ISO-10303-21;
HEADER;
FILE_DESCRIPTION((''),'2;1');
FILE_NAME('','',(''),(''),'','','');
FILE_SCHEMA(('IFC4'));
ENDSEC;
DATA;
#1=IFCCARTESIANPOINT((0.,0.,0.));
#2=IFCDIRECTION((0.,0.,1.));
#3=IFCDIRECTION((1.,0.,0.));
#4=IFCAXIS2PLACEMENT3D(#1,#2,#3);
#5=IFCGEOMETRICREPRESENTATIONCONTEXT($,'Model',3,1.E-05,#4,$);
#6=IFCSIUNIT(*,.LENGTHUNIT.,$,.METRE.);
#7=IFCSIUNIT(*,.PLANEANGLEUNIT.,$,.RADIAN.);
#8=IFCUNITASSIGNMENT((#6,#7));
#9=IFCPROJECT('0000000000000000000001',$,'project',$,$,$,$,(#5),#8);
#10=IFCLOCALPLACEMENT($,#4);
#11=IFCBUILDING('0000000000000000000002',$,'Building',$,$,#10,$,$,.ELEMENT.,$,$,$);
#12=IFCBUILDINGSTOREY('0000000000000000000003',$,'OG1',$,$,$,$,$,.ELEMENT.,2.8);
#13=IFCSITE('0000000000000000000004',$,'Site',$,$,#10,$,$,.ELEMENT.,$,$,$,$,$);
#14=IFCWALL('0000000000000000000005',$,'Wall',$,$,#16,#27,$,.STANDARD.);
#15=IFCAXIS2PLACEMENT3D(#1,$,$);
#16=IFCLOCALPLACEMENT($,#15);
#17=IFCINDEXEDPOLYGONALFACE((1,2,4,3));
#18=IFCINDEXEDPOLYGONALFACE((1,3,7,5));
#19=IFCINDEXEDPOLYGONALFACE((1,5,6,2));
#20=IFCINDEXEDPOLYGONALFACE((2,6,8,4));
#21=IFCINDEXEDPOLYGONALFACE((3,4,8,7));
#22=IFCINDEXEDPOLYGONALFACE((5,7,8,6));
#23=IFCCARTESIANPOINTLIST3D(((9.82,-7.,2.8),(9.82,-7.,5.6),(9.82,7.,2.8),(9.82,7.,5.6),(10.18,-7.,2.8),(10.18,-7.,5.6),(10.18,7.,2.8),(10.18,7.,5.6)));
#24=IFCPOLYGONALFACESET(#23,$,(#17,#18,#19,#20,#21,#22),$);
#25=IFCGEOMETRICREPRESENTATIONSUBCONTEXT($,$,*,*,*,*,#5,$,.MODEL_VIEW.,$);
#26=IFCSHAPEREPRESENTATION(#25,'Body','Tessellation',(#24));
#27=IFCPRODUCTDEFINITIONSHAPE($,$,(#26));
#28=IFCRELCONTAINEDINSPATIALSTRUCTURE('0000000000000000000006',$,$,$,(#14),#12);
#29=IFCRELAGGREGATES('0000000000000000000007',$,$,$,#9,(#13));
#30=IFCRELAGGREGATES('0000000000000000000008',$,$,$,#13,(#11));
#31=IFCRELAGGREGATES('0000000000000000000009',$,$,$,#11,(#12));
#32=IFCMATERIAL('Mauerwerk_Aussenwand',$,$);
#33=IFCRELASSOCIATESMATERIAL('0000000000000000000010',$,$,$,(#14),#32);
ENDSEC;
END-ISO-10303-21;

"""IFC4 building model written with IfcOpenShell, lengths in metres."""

from ifc_helpers import new_model, si_unit, frame, frame_2d, origin, origin_with_axes, place, context, subcontext, project, spatial, rectangle, extrude, material, element, save


model = new_model("IFC4")

# Units and contexts
model_context = context("Model", 3, precision=1e-05, world=origin_with_axes())
sub_context = subcontext(model_context, None, None, "MODEL_VIEW")
ifc_project = project(units=[si_unit("LENGTHUNIT", "METRE"), si_unit("PLANEANGLEUNIT", "RADIAN")], contexts=[model_context])

# Site, building, storey
placement_1 = place(None, origin_with_axes())
site = spatial("IfcSite", under=ifc_project, at=placement_1, Name="Site", CompositionType="ELEMENT")
building = spatial("IfcBuilding", under=site, at=placement_1, Name="Building", CompositionType="ELEMENT")
storey = spatial("IfcBuildingStorey", under=building, Name="OG1", CompositionType="ELEMENT", Elevation=2.8)

# Wall
ifc_material = material(Name="Mauerwerk_Aussenwand")
placement_2 = place(None, origin_with_axes())
placement_3 = place(placement_2, frame((0.0, 0.0, 2.8)))
wall_placement = place(placement_3, frame((10.0, -7.0, 0.0), x_axis=(0.0, 1.0, 0.0)))
element("IfcWall", 1, at=wall_placement, inside=storey, material=ifc_material, Name="Wall", PredefinedType="STANDARD", context=sub_context, shape_type="SweptSolid", body=[
    extrude(rectangle(XDim=14.0, YDim=0.36, at=frame_2d((7.0, 0.0))), origin(), (0.0, 0.0, 1.0), 2.8),
])

save(model, "model.ifc")
